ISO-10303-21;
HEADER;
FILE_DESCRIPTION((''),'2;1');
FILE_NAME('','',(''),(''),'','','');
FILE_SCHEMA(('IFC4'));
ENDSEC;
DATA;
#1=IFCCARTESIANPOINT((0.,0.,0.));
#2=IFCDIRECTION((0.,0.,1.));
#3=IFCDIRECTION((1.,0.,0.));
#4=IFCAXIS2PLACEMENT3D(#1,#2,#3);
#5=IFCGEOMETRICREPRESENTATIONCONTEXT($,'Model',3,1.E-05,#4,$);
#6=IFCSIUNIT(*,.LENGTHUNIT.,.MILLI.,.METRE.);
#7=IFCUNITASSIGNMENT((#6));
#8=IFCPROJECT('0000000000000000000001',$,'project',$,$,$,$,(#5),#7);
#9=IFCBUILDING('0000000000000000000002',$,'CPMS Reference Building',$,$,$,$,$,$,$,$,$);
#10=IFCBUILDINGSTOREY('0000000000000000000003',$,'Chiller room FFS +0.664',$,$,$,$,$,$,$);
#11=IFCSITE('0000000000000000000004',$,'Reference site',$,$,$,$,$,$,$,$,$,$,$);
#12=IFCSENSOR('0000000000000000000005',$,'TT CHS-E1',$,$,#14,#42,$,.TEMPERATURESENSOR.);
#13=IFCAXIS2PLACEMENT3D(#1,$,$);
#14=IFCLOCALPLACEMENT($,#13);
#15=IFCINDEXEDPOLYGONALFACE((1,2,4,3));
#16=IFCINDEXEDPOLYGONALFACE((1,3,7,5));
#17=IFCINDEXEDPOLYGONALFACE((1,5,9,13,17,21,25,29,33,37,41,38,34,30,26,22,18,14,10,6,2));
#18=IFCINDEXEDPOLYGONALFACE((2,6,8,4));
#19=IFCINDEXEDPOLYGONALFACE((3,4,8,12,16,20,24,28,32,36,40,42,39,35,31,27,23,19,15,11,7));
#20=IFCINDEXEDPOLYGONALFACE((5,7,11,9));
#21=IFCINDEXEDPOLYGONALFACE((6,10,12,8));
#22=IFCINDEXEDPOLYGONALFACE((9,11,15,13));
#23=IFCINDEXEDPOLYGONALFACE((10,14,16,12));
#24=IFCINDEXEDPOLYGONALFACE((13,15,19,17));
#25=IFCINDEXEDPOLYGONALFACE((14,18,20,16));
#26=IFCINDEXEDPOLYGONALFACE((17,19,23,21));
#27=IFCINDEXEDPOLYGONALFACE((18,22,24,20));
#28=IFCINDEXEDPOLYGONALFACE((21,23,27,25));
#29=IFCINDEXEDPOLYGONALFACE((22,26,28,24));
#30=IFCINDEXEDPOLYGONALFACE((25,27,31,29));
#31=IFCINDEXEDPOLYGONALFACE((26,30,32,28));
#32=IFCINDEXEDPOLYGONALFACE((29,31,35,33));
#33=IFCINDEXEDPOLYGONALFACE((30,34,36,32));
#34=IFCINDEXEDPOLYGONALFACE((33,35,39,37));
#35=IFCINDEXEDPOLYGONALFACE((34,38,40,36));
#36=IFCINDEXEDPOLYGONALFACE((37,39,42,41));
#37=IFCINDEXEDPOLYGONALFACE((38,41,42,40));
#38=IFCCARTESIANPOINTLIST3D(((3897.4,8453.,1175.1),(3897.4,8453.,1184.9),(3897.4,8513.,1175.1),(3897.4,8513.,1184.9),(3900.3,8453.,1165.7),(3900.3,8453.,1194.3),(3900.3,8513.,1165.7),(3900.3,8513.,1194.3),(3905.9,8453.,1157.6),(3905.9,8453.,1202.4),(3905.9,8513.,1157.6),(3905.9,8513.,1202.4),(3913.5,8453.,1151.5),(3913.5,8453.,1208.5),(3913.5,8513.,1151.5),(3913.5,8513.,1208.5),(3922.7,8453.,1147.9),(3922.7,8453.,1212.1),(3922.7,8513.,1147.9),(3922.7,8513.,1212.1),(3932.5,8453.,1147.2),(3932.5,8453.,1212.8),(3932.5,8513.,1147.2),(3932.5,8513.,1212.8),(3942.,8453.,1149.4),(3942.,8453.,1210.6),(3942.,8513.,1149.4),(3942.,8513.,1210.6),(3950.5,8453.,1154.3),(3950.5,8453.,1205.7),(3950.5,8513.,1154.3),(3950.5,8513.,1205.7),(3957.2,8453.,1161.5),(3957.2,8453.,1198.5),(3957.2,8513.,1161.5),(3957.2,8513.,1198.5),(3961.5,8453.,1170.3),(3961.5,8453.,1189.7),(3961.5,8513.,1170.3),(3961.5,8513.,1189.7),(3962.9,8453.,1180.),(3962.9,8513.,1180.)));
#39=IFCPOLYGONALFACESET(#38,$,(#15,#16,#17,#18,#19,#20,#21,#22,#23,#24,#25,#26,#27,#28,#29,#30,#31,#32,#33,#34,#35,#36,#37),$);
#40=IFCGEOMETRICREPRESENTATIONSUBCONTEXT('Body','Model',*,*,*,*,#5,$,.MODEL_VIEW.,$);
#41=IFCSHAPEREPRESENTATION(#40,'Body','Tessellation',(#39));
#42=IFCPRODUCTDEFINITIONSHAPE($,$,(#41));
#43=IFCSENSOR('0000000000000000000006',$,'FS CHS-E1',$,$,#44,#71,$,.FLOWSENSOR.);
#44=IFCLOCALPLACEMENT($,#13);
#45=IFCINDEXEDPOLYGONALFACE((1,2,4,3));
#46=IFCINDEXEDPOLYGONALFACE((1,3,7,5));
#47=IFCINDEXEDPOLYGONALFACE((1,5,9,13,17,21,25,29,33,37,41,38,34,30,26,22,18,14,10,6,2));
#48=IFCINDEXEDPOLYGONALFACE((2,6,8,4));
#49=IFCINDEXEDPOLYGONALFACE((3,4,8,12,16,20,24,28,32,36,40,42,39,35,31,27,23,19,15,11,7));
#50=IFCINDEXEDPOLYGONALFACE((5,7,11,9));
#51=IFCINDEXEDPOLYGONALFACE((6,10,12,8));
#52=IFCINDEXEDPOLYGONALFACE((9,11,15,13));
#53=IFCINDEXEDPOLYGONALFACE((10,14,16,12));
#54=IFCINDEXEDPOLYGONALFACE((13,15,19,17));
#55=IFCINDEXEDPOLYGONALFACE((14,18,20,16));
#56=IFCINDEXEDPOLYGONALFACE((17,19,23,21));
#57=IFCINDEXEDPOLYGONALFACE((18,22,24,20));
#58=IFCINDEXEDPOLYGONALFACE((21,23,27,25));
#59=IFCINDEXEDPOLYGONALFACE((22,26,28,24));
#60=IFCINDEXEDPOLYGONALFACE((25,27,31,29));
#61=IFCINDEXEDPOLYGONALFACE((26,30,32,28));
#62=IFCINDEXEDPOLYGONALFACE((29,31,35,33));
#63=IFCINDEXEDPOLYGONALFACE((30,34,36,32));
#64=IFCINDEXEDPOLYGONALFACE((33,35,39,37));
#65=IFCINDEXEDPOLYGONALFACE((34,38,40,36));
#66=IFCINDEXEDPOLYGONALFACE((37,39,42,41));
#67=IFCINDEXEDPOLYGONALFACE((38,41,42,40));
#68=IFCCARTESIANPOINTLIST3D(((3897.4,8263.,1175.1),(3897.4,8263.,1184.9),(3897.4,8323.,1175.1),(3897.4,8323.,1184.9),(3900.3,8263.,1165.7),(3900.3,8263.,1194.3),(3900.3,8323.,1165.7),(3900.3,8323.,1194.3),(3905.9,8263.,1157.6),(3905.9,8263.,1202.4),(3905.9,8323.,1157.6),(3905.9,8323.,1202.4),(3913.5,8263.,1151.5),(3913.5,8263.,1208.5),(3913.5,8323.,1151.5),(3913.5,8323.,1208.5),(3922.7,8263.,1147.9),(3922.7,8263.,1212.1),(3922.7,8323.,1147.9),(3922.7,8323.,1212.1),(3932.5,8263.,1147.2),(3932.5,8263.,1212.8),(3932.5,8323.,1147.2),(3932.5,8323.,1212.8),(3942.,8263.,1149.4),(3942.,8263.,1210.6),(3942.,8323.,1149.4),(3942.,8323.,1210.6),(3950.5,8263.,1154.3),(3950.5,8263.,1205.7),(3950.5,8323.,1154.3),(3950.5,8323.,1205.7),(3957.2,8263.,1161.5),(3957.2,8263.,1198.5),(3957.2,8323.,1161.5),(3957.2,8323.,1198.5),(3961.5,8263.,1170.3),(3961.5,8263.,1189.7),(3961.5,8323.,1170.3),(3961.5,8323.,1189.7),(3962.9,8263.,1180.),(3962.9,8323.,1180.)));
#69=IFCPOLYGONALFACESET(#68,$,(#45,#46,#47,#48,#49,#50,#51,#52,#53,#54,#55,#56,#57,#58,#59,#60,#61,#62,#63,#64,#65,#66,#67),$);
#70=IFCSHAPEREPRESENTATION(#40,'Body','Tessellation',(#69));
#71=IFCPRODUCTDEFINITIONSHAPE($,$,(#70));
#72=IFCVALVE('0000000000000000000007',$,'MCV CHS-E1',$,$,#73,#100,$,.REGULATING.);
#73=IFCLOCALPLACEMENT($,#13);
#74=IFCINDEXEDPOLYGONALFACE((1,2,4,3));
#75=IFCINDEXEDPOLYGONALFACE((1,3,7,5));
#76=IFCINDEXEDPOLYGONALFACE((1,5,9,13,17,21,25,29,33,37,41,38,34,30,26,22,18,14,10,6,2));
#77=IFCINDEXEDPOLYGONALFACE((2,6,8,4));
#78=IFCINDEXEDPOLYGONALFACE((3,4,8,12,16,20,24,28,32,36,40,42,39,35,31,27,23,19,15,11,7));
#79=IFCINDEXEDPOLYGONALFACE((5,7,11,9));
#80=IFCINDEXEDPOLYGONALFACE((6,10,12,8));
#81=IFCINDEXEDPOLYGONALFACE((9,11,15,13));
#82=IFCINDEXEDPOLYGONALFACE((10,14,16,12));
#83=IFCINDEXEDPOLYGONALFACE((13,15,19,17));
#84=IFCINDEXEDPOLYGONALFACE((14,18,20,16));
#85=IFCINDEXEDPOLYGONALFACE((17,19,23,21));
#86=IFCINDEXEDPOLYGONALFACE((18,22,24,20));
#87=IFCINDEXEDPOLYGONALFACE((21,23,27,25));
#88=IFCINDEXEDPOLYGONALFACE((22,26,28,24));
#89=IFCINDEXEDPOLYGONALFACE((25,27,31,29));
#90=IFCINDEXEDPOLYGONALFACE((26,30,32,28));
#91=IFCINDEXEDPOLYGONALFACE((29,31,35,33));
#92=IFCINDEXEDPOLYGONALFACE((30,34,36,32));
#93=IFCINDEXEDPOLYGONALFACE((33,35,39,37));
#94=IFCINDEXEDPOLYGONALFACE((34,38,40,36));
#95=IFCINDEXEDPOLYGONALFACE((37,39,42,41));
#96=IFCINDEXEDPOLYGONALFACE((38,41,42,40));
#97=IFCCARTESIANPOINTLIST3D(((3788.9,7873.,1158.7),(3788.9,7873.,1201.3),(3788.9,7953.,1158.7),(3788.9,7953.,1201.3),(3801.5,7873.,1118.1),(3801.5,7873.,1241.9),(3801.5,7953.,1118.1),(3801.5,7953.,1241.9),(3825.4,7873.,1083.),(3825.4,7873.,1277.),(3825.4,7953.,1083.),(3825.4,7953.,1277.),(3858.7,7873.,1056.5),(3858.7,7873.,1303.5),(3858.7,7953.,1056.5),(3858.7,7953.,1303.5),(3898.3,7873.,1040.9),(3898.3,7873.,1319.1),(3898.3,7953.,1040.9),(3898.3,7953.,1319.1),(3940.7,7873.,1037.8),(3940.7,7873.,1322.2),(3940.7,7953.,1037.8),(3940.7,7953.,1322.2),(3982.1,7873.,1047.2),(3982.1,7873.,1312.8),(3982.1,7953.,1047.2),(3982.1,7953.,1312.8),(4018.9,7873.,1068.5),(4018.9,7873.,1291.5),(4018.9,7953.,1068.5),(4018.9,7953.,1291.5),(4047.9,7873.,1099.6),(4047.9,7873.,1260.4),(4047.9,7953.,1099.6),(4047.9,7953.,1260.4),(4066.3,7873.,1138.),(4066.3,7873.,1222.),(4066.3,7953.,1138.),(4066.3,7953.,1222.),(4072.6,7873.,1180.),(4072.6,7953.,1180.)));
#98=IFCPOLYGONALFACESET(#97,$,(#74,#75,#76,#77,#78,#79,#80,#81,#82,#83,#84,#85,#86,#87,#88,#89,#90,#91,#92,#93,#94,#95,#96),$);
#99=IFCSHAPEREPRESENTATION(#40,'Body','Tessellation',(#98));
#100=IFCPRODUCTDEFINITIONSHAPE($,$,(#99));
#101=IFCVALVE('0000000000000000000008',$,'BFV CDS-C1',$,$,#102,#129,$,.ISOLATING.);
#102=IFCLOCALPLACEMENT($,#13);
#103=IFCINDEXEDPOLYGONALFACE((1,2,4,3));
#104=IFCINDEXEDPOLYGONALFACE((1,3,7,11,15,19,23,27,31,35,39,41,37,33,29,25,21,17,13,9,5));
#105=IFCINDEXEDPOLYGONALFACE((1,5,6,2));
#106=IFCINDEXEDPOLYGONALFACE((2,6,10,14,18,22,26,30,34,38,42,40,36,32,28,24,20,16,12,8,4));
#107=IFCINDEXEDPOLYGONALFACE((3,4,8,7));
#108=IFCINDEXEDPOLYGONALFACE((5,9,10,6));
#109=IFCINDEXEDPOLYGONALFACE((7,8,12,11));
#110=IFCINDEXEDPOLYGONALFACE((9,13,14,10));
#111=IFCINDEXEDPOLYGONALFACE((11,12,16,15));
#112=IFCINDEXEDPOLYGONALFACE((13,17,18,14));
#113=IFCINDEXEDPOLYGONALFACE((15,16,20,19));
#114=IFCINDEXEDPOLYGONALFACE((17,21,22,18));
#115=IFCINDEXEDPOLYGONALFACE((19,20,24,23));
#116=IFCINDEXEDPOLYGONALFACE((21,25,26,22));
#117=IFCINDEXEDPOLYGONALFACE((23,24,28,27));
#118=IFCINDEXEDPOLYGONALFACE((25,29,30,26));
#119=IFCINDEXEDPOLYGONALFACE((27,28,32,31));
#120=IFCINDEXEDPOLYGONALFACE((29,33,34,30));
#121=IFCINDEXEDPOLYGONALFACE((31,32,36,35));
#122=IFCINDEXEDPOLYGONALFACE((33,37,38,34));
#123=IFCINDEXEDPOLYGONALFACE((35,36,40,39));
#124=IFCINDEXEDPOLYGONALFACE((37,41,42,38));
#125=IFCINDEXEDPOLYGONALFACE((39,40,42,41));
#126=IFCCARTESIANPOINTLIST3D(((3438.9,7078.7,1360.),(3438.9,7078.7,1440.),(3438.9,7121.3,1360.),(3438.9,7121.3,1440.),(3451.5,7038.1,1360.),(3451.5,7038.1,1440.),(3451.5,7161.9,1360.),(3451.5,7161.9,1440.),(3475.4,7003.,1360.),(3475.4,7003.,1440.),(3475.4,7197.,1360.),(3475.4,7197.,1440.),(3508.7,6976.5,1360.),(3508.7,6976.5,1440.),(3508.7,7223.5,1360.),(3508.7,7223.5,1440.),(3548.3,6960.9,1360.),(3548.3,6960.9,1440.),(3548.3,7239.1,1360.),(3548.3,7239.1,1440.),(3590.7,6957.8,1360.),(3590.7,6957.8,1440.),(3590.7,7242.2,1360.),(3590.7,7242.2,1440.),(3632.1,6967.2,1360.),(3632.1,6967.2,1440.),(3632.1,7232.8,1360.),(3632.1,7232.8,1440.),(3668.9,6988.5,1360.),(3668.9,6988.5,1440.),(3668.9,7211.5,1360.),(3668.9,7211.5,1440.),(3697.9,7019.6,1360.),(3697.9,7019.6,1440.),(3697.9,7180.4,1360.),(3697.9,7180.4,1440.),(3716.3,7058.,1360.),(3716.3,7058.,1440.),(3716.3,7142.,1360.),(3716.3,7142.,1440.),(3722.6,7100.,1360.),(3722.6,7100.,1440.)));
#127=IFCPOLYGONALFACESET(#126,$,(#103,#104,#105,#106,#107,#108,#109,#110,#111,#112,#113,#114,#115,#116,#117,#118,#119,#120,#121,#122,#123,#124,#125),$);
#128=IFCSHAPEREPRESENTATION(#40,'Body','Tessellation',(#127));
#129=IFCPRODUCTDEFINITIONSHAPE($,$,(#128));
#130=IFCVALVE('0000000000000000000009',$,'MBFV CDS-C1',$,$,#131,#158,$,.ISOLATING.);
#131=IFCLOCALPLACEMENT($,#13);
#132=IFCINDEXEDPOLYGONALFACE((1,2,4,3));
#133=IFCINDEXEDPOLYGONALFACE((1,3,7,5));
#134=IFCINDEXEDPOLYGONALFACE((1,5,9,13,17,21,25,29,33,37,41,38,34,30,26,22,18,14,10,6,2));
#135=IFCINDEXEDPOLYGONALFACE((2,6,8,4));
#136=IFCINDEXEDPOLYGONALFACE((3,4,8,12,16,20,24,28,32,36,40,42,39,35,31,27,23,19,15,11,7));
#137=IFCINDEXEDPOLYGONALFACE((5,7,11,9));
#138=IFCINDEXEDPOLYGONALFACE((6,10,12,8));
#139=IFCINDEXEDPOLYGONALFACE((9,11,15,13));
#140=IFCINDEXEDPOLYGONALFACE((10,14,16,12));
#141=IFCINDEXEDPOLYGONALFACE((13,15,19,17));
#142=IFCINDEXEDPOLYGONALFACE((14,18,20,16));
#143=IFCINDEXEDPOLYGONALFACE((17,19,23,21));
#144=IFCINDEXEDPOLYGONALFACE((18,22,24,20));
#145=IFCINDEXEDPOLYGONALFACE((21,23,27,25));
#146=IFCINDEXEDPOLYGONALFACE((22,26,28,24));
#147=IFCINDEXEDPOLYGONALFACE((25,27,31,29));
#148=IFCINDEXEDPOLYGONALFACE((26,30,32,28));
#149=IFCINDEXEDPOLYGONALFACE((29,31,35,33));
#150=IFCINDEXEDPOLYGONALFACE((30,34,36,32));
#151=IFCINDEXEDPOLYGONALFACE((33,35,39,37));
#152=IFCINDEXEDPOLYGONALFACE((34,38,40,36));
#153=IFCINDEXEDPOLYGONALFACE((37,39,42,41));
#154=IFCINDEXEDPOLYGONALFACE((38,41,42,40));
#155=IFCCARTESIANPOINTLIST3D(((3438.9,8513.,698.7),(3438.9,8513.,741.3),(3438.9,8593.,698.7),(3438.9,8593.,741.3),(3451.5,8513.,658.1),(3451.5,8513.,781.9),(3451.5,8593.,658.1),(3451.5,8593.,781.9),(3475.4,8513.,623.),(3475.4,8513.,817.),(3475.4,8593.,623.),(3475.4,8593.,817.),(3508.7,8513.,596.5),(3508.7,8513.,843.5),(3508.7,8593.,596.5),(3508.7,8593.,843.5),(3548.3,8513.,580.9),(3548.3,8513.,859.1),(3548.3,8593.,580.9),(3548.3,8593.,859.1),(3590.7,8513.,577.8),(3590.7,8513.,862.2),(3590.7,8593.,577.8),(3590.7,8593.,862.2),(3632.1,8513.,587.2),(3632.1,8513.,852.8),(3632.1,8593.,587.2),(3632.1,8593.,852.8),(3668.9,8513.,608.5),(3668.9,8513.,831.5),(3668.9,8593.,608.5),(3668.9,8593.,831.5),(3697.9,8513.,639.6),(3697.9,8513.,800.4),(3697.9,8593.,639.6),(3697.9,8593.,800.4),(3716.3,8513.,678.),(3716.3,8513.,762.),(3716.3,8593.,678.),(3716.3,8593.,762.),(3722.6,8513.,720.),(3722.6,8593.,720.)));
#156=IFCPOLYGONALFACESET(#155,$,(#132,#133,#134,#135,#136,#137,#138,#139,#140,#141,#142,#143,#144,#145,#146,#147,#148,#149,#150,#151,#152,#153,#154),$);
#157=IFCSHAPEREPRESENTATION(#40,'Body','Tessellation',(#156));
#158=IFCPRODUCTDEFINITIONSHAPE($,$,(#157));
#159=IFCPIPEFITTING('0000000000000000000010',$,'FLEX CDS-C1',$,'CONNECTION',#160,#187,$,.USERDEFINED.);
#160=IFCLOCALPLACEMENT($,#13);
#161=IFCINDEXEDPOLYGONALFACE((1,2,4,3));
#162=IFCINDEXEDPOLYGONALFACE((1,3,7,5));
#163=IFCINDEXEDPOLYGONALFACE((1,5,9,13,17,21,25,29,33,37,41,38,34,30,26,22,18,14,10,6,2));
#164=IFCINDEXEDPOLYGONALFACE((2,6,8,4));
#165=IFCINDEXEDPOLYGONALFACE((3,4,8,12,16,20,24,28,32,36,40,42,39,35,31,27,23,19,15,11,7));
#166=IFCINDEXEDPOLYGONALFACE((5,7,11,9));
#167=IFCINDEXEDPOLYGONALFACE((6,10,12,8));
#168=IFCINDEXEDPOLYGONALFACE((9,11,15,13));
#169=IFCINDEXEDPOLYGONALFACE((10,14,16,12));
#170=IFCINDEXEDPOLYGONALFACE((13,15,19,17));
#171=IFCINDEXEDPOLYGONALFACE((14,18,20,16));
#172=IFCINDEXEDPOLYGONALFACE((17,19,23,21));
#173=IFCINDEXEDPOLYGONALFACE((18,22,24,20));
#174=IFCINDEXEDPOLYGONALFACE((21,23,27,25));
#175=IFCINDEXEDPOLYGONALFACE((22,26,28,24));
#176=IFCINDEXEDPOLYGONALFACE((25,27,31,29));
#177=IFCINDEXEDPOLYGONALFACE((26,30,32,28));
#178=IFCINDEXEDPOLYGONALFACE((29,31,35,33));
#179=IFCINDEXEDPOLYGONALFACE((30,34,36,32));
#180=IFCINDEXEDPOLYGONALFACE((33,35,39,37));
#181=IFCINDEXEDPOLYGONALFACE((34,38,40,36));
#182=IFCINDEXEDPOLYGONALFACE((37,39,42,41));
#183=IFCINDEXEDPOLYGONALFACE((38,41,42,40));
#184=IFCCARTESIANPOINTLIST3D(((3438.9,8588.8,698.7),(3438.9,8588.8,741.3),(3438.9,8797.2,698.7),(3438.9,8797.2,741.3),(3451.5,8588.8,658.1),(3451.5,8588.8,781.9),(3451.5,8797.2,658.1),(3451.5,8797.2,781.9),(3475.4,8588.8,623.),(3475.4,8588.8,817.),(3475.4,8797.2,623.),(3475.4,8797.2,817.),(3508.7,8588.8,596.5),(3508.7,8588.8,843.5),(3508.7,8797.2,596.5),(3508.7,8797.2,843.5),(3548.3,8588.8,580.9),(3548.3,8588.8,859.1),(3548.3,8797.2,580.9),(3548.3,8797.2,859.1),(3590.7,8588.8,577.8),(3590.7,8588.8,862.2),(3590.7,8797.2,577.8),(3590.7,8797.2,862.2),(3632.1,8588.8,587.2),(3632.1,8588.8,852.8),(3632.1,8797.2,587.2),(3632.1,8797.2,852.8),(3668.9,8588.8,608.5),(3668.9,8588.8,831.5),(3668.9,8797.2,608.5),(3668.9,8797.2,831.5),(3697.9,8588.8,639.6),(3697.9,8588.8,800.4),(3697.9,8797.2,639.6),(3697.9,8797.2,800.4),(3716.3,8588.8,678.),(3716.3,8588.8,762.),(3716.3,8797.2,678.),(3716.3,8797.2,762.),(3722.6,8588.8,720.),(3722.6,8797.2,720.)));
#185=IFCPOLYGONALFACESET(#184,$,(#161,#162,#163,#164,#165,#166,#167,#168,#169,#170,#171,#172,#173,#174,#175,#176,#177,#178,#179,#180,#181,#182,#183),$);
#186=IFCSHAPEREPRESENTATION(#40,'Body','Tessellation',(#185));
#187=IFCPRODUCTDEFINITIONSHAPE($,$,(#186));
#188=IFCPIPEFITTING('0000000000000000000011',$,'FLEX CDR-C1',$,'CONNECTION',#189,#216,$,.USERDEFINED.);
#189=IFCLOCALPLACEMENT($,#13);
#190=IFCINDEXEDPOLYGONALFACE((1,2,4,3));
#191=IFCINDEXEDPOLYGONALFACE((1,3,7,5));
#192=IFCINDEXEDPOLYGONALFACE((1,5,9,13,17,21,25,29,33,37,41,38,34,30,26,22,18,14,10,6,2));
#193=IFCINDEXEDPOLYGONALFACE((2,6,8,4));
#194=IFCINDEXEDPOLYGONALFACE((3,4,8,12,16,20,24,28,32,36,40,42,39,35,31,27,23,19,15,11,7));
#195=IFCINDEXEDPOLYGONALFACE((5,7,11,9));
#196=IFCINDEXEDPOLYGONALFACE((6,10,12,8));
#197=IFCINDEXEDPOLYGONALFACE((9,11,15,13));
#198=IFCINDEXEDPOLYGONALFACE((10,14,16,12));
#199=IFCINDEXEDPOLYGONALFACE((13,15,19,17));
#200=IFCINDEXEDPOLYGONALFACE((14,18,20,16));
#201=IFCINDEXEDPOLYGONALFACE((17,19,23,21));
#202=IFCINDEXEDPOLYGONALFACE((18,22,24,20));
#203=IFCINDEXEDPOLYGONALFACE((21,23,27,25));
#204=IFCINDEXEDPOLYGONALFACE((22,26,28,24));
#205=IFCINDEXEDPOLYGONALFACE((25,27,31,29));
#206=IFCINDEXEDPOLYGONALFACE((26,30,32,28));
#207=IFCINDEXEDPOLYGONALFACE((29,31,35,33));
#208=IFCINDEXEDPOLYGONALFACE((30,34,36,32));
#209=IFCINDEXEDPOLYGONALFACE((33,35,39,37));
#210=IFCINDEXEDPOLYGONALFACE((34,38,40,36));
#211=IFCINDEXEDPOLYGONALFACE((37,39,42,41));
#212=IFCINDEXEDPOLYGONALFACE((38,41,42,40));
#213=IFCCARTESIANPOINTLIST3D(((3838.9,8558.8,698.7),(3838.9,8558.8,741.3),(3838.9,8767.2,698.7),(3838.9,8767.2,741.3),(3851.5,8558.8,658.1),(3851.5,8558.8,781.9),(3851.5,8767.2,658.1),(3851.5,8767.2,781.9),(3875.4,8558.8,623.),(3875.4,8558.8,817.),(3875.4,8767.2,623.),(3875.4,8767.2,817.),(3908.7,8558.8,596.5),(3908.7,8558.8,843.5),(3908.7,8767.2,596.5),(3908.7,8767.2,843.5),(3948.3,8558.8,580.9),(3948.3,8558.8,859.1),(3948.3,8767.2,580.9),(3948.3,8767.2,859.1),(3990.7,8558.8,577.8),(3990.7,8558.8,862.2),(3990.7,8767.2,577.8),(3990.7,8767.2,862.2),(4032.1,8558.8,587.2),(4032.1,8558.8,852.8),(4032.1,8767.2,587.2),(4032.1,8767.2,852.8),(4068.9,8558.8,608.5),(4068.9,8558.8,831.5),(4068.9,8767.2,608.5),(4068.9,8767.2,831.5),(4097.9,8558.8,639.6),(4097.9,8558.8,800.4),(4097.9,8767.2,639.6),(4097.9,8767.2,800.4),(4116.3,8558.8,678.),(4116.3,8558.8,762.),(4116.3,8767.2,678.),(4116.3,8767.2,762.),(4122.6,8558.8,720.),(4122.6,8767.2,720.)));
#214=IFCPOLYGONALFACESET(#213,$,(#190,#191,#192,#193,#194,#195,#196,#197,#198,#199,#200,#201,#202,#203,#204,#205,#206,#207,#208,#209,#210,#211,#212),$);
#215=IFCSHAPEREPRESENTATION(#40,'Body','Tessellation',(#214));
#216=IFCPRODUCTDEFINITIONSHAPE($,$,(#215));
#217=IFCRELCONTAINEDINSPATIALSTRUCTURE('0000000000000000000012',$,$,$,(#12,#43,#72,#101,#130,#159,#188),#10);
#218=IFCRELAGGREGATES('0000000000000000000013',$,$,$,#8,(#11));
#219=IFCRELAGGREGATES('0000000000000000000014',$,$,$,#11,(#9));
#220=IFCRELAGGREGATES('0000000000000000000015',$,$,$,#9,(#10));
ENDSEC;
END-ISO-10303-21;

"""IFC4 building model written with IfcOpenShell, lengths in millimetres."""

from ifc_helpers import new_model, si_unit, frame, origin_with_axes, origin_2d, place, context, subcontext, project, spatial, circle_curve, outline, extrude, element, save


model = new_model("IFC4")

# Units and contexts
model_context = context("Model", 3, precision=1e-05, world=origin_with_axes())
body_context = subcontext(model_context, "Body", "Model", "MODEL_VIEW")
ifc_project = project(units=[si_unit("LENGTHUNIT", "METRE", prefix="MILLI")], contexts=[model_context])

# Site, building, storey
site = spatial("IfcSite", under=ifc_project, Name="Reference site")
building = spatial("IfcBuilding", under=site, Name="CPMS Reference Building")
storey = spatial("IfcBuildingStorey", under=building, Name="Chiller room FFS +0.664")

# Sensors
sensor_1_placement = place(None, origin_with_axes())
element("IfcSensor", 1, at=sensor_1_placement, inside=storey, Name="TT CHS-E1", PredefinedType="TEMPERATURESENSOR", context=body_context, shape_type="SweptSolid", body=[
    extrude(outline(circle_curve(origin_2d(), 32.9)), frame((3930.0, 8513.0, 1180.0), z_axis=(0.0, -1.0, 0.0), x_axis=(1.0, 0.0, 0.0)), (0.0, 0.0, 1.0), 60.0),
])
sensor_2_placement = place(None, origin_with_axes())
element("IfcSensor", 2, at=sensor_2_placement, inside=storey, Name="FS CHS-E1", PredefinedType="FLOWSENSOR", context=body_context, shape_type="SweptSolid", body=[
    extrude(outline(circle_curve(origin_2d(), 32.9)), frame((3930.0, 8323.0, 1180.0), z_axis=(0.0, -1.0, 0.0), x_axis=(1.0, 0.0, 0.0)), (0.0, 0.0, 1.0), 60.0),
])

# Valves
valve_1_placement = place(None, origin_with_axes())
element("IfcValve", 3, at=valve_1_placement, inside=storey, Name="MCV CHS-E1", PredefinedType="REGULATING", context=body_context, shape_type="SweptSolid", body=[
    extrude(outline(circle_curve(origin_2d(), 142.6)), frame((3930.0, 7953.0, 1180.0), z_axis=(0.0, -1.0, 0.0), x_axis=(1.0, 0.0, 0.0)), (0.0, 0.0, 1.0), 80.0),
])
valve_2_placement = place(None, origin_with_axes())
element("IfcValve", 4, at=valve_2_placement, inside=storey, Name="BFV CDS-C1", PredefinedType="ISOLATING", context=body_context, shape_type="SweptSolid", body=[
    extrude(outline(circle_curve(origin_2d(), 142.6)), frame((3580.0, 7100.0, 1440.0), z_axis=(0.0, 0.0, -1.0), x_axis=(1.0, 0.0, 0.0)), (0.0, 0.0, 1.0), 80.0),
])
valve_3_placement = place(None, origin_with_axes())
element("IfcValve", 5, at=valve_3_placement, inside=storey, Name="MBFV CDS-C1", PredefinedType="ISOLATING", context=body_context, shape_type="SweptSolid", body=[
    extrude(outline(circle_curve(origin_2d(), 142.6)), frame((3580.0, 8513.0, 720.0), z_axis=(0.0, 1.0, 0.0), x_axis=(1.0, 0.0, 0.0)), (0.0, 0.0, 1.0), 80.0),
])

# Pipe fittings
pipe_fitting_1_placement = place(None, origin_with_axes())
element("IfcPipeFitting", 6, at=pipe_fitting_1_placement, inside=storey, Name="FLEX CDS-C1", ObjectType="CONNECTION", PredefinedType="USERDEFINED", context=body_context, shape_type="SweptSolid", body=[
    extrude(outline(circle_curve(origin_2d(), 142.6)), frame((3580.0, 8588.8, 720.0), z_axis=(0.0, 1.0, 0.0), x_axis=(1.0, 0.0, 0.0)), (0.0, 0.0, 1.0), 208.5),
])
pipe_fitting_2_placement = place(None, origin_with_axes())
element("IfcPipeFitting", 7, at=pipe_fitting_2_placement, inside=storey, Name="FLEX CDR-C1", ObjectType="CONNECTION", PredefinedType="USERDEFINED", context=body_context, shape_type="SweptSolid", body=[
    extrude(outline(circle_curve(origin_2d(), 142.6)), frame((3980.0, 8767.2, 720.0), z_axis=(0.0, -1.0, 0.0), x_axis=(1.0, 0.0, 0.0)), (0.0, 0.0, 1.0), 208.5),
])

save(model, "model.ifc")
